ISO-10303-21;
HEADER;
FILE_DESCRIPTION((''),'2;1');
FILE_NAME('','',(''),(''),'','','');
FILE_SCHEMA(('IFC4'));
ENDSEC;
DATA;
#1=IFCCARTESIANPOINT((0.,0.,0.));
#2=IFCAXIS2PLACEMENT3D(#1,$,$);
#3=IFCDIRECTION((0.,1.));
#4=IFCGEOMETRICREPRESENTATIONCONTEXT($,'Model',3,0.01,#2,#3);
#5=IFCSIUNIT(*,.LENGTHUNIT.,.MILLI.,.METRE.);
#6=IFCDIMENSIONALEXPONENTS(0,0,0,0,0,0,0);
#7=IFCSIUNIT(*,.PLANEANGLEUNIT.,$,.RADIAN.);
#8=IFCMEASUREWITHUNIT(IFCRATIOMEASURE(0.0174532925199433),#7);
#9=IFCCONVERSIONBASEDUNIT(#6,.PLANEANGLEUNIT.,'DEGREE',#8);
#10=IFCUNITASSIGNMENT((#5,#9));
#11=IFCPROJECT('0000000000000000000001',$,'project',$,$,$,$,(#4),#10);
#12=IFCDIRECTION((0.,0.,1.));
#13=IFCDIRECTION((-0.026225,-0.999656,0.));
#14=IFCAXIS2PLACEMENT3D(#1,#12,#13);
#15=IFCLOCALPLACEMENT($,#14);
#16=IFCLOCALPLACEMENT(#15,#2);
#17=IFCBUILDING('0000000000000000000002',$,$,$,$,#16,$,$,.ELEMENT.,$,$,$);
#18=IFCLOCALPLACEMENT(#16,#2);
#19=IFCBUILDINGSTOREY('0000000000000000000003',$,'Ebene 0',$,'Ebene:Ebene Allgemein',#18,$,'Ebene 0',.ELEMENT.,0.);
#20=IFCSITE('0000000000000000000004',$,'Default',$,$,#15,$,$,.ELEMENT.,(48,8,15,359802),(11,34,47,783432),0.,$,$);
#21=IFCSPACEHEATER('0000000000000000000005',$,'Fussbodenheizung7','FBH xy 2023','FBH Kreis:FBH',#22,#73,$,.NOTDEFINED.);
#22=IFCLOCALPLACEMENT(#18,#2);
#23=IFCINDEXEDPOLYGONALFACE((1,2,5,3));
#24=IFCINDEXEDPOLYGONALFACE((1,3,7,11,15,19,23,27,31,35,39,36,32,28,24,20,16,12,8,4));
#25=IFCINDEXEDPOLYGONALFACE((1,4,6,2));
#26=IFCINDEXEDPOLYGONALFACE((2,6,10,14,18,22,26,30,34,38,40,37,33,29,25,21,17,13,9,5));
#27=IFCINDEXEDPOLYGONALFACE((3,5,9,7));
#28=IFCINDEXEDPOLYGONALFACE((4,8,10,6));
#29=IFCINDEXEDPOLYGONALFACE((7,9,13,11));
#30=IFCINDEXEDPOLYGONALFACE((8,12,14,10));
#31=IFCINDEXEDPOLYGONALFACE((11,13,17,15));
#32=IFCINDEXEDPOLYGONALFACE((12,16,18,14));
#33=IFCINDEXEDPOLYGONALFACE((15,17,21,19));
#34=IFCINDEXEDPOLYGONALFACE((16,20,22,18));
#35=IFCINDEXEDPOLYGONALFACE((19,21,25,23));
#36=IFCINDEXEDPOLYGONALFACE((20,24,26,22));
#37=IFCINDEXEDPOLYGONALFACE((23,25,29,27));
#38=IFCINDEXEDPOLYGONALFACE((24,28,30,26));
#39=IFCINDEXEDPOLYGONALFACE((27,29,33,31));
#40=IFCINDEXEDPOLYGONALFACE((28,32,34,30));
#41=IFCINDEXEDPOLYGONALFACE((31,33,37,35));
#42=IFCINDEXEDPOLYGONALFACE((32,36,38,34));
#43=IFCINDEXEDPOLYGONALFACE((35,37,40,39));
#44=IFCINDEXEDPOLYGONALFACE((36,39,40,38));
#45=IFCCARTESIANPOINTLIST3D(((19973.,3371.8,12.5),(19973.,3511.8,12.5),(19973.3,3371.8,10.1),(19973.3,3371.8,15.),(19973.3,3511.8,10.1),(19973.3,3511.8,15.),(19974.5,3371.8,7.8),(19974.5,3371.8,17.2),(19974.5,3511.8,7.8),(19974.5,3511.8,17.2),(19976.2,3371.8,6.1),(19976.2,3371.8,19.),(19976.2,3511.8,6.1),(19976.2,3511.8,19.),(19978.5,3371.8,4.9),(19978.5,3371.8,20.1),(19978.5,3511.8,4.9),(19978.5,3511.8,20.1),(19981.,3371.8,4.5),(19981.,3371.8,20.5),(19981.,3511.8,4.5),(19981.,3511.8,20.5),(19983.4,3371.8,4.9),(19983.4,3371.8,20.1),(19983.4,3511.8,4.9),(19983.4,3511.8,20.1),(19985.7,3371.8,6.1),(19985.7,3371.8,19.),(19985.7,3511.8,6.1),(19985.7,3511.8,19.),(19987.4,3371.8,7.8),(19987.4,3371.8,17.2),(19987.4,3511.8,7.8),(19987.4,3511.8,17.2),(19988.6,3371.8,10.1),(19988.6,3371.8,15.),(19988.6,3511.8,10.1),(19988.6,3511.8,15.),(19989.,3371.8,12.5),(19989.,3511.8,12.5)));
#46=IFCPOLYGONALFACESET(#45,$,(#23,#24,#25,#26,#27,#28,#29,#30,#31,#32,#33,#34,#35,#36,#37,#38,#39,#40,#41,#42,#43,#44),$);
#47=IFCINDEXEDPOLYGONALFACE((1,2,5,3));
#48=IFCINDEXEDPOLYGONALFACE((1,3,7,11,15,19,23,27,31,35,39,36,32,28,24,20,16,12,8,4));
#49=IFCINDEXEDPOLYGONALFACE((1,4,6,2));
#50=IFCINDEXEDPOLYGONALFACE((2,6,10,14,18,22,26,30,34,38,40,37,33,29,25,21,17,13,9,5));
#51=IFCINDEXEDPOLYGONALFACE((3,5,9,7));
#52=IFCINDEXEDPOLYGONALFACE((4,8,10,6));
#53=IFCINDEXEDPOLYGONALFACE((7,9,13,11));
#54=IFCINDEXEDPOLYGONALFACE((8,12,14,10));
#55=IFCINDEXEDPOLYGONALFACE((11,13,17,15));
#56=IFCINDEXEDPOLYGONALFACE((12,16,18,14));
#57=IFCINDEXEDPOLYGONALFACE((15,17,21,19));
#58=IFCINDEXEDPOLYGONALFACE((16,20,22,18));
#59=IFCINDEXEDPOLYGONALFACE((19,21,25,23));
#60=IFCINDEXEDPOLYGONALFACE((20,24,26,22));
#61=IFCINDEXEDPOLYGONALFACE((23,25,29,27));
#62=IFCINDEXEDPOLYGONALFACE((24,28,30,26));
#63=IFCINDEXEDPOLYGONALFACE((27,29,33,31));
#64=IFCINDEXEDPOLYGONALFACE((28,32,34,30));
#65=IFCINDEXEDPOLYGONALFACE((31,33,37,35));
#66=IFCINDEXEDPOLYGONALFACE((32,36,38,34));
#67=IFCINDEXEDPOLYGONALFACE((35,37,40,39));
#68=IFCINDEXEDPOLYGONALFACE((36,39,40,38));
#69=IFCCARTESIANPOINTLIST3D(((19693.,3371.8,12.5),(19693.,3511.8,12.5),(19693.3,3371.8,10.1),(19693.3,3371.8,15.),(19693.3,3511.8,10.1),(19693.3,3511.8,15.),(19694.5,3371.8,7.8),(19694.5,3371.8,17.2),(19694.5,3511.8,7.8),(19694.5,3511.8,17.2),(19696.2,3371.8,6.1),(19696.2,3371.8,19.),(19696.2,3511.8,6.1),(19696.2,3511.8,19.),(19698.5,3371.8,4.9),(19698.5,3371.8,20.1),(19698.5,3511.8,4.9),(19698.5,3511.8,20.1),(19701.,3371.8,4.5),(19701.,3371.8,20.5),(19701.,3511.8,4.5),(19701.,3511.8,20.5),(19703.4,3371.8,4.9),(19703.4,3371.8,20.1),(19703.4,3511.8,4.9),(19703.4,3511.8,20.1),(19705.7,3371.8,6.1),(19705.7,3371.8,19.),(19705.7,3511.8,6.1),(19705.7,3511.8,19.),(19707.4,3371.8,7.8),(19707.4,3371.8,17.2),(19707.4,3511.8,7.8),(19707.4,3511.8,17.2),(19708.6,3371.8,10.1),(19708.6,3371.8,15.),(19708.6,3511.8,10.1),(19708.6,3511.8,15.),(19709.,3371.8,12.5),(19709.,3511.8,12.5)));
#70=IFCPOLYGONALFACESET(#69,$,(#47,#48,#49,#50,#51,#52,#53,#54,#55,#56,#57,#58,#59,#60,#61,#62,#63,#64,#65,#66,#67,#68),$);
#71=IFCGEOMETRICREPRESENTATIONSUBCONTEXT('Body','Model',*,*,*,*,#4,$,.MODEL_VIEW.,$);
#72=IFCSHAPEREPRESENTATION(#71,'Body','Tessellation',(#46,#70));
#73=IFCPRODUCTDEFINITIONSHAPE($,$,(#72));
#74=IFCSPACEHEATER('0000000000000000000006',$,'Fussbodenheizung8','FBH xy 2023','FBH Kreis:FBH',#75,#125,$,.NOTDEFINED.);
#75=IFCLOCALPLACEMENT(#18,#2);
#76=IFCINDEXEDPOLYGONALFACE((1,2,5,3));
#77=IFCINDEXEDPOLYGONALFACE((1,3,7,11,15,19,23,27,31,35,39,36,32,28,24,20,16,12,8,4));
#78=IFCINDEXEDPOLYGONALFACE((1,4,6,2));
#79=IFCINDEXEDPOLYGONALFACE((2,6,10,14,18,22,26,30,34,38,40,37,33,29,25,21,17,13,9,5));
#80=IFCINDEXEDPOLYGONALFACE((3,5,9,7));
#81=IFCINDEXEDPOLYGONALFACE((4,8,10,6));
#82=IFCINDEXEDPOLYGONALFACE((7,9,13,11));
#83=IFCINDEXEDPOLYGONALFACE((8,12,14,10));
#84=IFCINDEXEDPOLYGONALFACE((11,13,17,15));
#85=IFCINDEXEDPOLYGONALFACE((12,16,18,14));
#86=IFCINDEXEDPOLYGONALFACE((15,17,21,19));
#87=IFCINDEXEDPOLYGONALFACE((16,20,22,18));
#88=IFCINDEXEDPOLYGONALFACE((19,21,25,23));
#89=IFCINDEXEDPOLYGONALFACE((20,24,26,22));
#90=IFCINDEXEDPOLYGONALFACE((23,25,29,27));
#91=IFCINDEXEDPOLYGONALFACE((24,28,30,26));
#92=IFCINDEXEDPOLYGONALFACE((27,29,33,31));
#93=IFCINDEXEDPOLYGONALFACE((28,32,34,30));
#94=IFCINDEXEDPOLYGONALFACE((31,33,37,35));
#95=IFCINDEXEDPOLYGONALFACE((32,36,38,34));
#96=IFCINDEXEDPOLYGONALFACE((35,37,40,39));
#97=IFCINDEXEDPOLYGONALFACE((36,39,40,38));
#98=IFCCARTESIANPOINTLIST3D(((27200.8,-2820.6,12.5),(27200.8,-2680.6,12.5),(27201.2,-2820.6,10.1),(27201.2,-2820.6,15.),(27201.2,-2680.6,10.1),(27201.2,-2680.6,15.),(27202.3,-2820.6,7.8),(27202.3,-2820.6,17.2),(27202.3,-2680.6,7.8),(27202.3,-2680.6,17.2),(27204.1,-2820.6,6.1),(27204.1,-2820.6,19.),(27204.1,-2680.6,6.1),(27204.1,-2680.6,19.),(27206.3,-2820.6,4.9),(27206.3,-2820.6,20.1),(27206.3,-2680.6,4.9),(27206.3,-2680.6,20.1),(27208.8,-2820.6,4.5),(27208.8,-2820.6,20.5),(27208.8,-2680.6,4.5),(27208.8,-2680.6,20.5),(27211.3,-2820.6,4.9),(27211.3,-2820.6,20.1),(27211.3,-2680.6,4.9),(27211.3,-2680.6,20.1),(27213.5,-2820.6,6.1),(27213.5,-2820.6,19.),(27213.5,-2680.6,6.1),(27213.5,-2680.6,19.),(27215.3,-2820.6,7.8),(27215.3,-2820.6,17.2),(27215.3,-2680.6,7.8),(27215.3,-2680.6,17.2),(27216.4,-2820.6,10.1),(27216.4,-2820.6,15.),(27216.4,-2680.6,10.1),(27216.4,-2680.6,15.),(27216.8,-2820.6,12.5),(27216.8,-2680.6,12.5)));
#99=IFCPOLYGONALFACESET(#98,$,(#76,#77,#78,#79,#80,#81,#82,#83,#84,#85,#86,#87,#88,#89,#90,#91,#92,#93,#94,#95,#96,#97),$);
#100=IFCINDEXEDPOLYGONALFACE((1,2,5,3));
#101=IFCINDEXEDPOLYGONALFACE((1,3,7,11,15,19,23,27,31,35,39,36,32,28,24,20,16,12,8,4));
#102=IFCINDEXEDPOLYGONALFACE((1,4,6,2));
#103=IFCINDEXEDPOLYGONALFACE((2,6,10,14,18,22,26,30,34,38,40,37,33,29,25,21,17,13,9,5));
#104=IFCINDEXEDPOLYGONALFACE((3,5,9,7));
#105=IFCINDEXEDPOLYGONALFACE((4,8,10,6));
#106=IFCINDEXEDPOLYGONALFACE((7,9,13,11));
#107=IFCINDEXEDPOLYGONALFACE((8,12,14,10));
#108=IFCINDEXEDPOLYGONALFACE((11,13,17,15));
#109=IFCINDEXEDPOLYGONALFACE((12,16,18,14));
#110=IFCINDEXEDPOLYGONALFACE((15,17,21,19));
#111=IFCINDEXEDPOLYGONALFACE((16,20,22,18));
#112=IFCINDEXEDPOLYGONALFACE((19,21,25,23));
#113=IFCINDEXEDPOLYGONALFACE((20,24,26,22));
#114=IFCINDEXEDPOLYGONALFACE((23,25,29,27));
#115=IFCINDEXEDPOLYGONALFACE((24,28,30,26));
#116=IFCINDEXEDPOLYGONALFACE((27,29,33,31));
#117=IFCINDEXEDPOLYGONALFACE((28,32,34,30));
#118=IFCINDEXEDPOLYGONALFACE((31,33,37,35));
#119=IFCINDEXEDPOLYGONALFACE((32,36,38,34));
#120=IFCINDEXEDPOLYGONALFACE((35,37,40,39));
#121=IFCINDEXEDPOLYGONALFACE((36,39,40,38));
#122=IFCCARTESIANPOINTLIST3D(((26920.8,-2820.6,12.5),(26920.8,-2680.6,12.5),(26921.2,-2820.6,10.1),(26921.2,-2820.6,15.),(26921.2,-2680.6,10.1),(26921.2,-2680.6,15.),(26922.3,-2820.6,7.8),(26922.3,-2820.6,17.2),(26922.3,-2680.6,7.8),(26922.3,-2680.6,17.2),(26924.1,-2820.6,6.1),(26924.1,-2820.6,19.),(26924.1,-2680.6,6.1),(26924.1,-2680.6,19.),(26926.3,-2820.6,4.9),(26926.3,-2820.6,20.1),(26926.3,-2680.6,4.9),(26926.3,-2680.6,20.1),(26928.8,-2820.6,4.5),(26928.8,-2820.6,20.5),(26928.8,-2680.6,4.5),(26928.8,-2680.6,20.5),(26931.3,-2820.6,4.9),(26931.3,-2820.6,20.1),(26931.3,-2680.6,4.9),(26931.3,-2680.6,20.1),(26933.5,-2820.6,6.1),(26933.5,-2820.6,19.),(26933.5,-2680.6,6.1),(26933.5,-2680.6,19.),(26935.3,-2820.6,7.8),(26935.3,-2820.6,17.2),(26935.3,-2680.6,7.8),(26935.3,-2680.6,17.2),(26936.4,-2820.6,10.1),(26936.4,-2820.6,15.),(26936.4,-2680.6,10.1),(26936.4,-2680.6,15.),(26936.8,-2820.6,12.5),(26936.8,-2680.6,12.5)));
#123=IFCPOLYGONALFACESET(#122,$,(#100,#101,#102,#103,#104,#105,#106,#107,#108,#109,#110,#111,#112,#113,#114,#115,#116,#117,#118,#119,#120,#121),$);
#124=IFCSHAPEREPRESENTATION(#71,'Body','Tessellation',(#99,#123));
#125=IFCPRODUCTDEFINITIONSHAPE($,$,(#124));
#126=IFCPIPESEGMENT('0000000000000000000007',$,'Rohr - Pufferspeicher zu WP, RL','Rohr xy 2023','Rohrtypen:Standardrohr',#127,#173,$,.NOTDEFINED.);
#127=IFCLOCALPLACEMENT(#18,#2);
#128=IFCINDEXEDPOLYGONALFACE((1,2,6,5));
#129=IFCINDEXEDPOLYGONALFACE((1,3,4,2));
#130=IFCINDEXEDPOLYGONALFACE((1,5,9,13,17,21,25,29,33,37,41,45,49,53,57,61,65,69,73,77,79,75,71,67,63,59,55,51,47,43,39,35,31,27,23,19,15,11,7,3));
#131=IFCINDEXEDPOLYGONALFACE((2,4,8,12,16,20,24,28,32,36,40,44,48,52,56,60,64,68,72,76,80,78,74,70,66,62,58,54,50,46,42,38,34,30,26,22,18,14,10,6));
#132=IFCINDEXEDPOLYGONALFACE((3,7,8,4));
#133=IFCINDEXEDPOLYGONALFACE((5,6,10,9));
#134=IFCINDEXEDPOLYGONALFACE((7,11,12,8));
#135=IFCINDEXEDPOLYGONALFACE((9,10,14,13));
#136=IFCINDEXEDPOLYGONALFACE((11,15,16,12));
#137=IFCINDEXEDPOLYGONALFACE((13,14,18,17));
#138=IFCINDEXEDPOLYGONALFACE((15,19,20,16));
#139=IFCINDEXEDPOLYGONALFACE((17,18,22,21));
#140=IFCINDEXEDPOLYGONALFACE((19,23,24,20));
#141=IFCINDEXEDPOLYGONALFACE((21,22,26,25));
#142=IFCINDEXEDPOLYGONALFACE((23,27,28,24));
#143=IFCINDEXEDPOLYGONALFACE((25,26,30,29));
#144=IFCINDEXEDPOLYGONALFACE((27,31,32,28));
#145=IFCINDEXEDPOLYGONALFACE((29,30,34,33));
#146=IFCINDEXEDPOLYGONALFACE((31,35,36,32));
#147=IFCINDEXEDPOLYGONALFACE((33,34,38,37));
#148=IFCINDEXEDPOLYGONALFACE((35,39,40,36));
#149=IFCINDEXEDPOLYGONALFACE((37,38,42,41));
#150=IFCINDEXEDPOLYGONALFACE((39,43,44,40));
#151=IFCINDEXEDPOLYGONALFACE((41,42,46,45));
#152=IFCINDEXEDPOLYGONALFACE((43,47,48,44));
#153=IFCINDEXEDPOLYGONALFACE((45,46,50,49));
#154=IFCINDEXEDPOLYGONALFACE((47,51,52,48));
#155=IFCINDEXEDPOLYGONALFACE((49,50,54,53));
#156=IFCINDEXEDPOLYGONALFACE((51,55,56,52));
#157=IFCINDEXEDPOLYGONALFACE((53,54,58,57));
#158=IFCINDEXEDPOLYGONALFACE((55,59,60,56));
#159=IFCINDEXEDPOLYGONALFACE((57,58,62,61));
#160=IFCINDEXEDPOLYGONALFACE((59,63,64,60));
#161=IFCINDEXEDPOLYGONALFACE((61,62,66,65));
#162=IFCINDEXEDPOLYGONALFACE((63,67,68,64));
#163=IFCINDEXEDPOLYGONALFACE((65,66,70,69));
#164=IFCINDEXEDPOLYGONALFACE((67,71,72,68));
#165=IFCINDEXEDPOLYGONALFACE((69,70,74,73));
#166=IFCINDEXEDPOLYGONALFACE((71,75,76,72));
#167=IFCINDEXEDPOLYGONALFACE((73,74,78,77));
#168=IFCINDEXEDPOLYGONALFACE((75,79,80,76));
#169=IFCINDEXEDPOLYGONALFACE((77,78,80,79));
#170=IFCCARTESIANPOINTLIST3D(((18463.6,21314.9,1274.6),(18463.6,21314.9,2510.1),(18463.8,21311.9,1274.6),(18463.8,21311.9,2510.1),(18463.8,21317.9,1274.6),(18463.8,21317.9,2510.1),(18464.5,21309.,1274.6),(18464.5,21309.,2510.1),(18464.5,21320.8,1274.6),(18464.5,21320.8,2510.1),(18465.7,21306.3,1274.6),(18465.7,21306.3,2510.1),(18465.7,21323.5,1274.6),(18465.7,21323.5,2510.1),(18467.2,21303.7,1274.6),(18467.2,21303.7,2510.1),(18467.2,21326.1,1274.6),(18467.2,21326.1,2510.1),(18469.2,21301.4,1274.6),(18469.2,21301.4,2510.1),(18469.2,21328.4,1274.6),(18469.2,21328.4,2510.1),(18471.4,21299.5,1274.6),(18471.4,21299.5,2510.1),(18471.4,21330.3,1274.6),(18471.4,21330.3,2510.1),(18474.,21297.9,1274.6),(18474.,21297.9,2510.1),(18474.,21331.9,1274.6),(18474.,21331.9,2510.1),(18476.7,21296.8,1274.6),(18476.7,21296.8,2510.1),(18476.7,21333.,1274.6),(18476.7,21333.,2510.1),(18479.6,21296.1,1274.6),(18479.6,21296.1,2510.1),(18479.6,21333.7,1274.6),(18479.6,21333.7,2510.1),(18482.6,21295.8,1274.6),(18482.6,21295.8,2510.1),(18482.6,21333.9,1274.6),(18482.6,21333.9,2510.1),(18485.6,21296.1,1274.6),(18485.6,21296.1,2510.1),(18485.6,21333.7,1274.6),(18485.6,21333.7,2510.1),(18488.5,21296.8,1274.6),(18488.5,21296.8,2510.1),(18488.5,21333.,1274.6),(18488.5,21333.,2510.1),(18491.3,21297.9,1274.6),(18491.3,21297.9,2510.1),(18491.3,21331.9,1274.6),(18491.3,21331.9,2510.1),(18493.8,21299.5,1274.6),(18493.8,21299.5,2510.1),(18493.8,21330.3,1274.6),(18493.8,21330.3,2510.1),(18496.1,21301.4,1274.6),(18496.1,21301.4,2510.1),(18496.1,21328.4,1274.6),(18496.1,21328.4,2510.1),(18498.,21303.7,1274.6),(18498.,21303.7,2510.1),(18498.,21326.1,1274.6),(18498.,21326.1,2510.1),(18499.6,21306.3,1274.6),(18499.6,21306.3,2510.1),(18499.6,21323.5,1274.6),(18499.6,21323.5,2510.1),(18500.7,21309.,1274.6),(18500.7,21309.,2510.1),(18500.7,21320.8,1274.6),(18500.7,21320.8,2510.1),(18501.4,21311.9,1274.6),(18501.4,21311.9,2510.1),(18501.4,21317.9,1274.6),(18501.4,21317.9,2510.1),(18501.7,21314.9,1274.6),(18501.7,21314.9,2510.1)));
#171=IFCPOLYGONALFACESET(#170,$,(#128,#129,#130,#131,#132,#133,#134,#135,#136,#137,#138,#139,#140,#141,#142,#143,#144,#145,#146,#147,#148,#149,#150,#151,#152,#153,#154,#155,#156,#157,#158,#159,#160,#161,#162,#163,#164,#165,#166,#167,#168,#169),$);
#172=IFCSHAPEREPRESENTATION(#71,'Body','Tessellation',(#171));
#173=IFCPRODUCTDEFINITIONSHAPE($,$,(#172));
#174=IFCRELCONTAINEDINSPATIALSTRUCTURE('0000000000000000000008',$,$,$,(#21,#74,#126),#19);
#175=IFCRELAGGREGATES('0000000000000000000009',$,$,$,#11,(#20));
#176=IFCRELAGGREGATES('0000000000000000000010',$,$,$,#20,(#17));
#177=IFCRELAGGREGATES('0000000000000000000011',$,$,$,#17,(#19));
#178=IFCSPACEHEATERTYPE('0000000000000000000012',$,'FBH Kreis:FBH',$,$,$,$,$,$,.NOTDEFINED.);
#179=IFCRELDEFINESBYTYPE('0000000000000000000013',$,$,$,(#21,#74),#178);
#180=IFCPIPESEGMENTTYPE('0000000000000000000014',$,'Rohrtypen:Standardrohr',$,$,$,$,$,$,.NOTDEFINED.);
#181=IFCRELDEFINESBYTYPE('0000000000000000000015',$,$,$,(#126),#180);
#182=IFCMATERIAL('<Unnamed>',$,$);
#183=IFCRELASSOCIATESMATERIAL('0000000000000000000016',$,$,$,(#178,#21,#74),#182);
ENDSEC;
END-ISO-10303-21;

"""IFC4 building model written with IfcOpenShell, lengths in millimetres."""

from ifc_helpers import new_model, entity, si_unit, converted_unit, direction, frame, origin, place, context, subcontext, project, spatial, indexed_curve, outline, extrude, source, transform, mapped, material, type_object, type_shapes, element, save


model = new_model("IFC4")

# Units and contexts
model_context = context("Model", 3, precision=0.01, world=origin(), true_north=direction((0.0, 1.0)))
body_context = subcontext(model_context, "Body", "Model", "MODEL_VIEW")
ifc_project = project(units=[si_unit("LENGTHUNIT", "METRE", prefix="MILLI"), converted_unit("PLANEANGLEUNIT", "DEGREE", entity("IfcRatioMeasure", 0.0174532925199433), si_unit("PLANEANGLEUNIT", "RADIAN"), dimensions=[0, 0, 0, 0, 0, 0, 0])], contexts=[model_context])

# Site, building, storey
site_placement = place(None, frame((0.0, 0.0, 0.0), z_axis=(0.0, 0.0, 1.0), x_axis=(-0.026225, -0.999656, 0.0)))
site = spatial("IfcSite", under=ifc_project, at=site_placement, Name="Default", CompositionType="ELEMENT", RefLatitude=(48, 8, 15, 359802), RefLongitude=(11, 34, 47, 783432), RefElevation=0.0)
building_placement = place(site_placement, origin())
building = spatial("IfcBuilding", under=site, at=building_placement, CompositionType="ELEMENT")
storey_placement = place(building_placement, origin())
storey = spatial("IfcBuildingStorey", under=building, at=storey_placement, Name="Ebene 0", ObjectType="Ebene:Ebene Allgemein", LongName="Ebene 0", CompositionType="ELEMENT", Elevation=0.0)

# Space heaters
ifc_material = material(Name="<Unnamed>")
space_heater_type = type_object("IfcSpaceHeaterType", Name="FBH Kreis:FBH", PredefinedType="NOTDEFINED", material=ifc_material)
shared_shape = source(origin(), body_context, "Body", "SweptSolid", [
    extrude(outline(indexed_curve([(8.0, 0.0), (7.6, 2.5), (6.5, 4.7), (4.7, 6.5), (2.5, 7.6), (0.0, 8.0), (-2.5, 7.6), (-4.7, 6.5), (-6.5, 4.7), (-7.6, 2.5), (-8.0, 0.0), (-7.6, -2.5), (-6.5, -4.7), (-4.7, -6.5), (-2.5, -7.6), (0.0, -8.0), (2.5, -7.6), (4.7, -6.5), (6.5, -4.7), (7.6, -2.5), (8.0, 0.0)], self_intersect=False)), frame((140.0, -1621.8, -83.0), z_axis=(0.0, 1.0, 0.0), x_axis=(1.0, 0.0, 0.0)), (0.0, 0.0, 1.0), 140.0),
    extrude(outline(indexed_curve([(8.0, 0.0), (7.6, 2.5), (6.5, 4.7), (4.7, 6.5), (2.5, 7.6), (0.0, 8.0), (-2.5, 7.6), (-4.7, 6.5), (-6.5, 4.7), (-7.6, 2.5), (-8.0, 0.0), (-7.6, -2.5), (-6.5, -4.7), (-4.7, -6.5), (-2.5, -7.6), (0.0, -8.0), (2.5, -7.6), (4.7, -6.5), (6.5, -4.7), (7.6, -2.5), (8.0, 0.0)], self_intersect=False)), frame((-140.0, -1621.8, -83.0), z_axis=(0.0, 1.0, 0.0), x_axis=(1.0, 0.0, 0.0)), (0.0, 0.0, 1.0), 140.0),
])
type_shapes(space_heater_type, [shared_shape])
for number, where, name in (
    (1, (19841.0, 4993.5, 95.5), "Fussbodenheizung7"),
    (2, (27068.8, -1198.9, 95.5), "Fussbodenheizung8"),
):
    element("IfcSpaceHeater", number, at=place(storey_placement, frame(where)), inside=storey, type_object=space_heater_type, material=ifc_material, Name=name, Description="FBH xy 2023", ObjectType="FBH Kreis:FBH", PredefinedType="NOTDEFINED", context=body_context, shape_type="MappedRepresentation", body=[
        mapped(shared_shape, transform((0.0, 0.0, 0.0), scale=1.0)),
    ])

# Pipe segment
pipe_segment_type = type_object("IfcPipeSegmentType", Name="Rohrtypen:Standardrohr", PredefinedType="NOTDEFINED")
pipe_segment_1_placement = place(storey_placement, origin())
element("IfcPipeSegment", 3, at=pipe_segment_1_placement, inside=storey, type_object=pipe_segment_type, Name="Rohr - Pufferspeicher zu WP, RL", Description="Rohr xy 2023", ObjectType="Rohrtypen:Standardrohr", PredefinedType="NOTDEFINED", context=body_context, shape_type="SweptSolid", body=[
    extrude(outline(indexed_curve([(19.1, 0.0), (18.8, 3.0), (18.1, 5.9), (17.0, 8.6), (15.4, 11.2), (13.5, 13.5), (11.2, 15.4), (8.6, 17.0), (5.9, 18.1), (3.0, 18.8), (0.0, 19.1), (-3.0, 18.8), (-5.9, 18.1), (-8.6, 17.0), (-11.2, 15.4), (-13.5, 13.5), (-15.4, 11.2), (-17.0, 8.6), (-18.1, 5.9), (-18.8, 3.0), (-19.1, 0.0), (-18.8, -3.0), (-18.1, -5.9), (-17.0, -8.6), (-15.4, -11.2), (-13.5, -13.5), (-11.2, -15.4), (-8.6, -17.0), (-5.9, -18.1), (-3.0, -18.8), (0.0, -19.1), (3.0, -18.8), (5.9, -18.1), (8.6, -17.0), (11.2, -15.4), (13.5, -13.5), (15.4, -11.2), (17.0, -8.6), (18.1, -5.9), (18.8, -3.0), (19.1, 0.0)], self_intersect=False)), frame((18482.6, 21314.9, 1274.6), z_axis=(0.0, 0.0, 1.0), x_axis=(-1.0, 0.0, 0.0)), (0.0, 0.0, 1.0), 1235.5),
])

save(model, "model.ifc")
